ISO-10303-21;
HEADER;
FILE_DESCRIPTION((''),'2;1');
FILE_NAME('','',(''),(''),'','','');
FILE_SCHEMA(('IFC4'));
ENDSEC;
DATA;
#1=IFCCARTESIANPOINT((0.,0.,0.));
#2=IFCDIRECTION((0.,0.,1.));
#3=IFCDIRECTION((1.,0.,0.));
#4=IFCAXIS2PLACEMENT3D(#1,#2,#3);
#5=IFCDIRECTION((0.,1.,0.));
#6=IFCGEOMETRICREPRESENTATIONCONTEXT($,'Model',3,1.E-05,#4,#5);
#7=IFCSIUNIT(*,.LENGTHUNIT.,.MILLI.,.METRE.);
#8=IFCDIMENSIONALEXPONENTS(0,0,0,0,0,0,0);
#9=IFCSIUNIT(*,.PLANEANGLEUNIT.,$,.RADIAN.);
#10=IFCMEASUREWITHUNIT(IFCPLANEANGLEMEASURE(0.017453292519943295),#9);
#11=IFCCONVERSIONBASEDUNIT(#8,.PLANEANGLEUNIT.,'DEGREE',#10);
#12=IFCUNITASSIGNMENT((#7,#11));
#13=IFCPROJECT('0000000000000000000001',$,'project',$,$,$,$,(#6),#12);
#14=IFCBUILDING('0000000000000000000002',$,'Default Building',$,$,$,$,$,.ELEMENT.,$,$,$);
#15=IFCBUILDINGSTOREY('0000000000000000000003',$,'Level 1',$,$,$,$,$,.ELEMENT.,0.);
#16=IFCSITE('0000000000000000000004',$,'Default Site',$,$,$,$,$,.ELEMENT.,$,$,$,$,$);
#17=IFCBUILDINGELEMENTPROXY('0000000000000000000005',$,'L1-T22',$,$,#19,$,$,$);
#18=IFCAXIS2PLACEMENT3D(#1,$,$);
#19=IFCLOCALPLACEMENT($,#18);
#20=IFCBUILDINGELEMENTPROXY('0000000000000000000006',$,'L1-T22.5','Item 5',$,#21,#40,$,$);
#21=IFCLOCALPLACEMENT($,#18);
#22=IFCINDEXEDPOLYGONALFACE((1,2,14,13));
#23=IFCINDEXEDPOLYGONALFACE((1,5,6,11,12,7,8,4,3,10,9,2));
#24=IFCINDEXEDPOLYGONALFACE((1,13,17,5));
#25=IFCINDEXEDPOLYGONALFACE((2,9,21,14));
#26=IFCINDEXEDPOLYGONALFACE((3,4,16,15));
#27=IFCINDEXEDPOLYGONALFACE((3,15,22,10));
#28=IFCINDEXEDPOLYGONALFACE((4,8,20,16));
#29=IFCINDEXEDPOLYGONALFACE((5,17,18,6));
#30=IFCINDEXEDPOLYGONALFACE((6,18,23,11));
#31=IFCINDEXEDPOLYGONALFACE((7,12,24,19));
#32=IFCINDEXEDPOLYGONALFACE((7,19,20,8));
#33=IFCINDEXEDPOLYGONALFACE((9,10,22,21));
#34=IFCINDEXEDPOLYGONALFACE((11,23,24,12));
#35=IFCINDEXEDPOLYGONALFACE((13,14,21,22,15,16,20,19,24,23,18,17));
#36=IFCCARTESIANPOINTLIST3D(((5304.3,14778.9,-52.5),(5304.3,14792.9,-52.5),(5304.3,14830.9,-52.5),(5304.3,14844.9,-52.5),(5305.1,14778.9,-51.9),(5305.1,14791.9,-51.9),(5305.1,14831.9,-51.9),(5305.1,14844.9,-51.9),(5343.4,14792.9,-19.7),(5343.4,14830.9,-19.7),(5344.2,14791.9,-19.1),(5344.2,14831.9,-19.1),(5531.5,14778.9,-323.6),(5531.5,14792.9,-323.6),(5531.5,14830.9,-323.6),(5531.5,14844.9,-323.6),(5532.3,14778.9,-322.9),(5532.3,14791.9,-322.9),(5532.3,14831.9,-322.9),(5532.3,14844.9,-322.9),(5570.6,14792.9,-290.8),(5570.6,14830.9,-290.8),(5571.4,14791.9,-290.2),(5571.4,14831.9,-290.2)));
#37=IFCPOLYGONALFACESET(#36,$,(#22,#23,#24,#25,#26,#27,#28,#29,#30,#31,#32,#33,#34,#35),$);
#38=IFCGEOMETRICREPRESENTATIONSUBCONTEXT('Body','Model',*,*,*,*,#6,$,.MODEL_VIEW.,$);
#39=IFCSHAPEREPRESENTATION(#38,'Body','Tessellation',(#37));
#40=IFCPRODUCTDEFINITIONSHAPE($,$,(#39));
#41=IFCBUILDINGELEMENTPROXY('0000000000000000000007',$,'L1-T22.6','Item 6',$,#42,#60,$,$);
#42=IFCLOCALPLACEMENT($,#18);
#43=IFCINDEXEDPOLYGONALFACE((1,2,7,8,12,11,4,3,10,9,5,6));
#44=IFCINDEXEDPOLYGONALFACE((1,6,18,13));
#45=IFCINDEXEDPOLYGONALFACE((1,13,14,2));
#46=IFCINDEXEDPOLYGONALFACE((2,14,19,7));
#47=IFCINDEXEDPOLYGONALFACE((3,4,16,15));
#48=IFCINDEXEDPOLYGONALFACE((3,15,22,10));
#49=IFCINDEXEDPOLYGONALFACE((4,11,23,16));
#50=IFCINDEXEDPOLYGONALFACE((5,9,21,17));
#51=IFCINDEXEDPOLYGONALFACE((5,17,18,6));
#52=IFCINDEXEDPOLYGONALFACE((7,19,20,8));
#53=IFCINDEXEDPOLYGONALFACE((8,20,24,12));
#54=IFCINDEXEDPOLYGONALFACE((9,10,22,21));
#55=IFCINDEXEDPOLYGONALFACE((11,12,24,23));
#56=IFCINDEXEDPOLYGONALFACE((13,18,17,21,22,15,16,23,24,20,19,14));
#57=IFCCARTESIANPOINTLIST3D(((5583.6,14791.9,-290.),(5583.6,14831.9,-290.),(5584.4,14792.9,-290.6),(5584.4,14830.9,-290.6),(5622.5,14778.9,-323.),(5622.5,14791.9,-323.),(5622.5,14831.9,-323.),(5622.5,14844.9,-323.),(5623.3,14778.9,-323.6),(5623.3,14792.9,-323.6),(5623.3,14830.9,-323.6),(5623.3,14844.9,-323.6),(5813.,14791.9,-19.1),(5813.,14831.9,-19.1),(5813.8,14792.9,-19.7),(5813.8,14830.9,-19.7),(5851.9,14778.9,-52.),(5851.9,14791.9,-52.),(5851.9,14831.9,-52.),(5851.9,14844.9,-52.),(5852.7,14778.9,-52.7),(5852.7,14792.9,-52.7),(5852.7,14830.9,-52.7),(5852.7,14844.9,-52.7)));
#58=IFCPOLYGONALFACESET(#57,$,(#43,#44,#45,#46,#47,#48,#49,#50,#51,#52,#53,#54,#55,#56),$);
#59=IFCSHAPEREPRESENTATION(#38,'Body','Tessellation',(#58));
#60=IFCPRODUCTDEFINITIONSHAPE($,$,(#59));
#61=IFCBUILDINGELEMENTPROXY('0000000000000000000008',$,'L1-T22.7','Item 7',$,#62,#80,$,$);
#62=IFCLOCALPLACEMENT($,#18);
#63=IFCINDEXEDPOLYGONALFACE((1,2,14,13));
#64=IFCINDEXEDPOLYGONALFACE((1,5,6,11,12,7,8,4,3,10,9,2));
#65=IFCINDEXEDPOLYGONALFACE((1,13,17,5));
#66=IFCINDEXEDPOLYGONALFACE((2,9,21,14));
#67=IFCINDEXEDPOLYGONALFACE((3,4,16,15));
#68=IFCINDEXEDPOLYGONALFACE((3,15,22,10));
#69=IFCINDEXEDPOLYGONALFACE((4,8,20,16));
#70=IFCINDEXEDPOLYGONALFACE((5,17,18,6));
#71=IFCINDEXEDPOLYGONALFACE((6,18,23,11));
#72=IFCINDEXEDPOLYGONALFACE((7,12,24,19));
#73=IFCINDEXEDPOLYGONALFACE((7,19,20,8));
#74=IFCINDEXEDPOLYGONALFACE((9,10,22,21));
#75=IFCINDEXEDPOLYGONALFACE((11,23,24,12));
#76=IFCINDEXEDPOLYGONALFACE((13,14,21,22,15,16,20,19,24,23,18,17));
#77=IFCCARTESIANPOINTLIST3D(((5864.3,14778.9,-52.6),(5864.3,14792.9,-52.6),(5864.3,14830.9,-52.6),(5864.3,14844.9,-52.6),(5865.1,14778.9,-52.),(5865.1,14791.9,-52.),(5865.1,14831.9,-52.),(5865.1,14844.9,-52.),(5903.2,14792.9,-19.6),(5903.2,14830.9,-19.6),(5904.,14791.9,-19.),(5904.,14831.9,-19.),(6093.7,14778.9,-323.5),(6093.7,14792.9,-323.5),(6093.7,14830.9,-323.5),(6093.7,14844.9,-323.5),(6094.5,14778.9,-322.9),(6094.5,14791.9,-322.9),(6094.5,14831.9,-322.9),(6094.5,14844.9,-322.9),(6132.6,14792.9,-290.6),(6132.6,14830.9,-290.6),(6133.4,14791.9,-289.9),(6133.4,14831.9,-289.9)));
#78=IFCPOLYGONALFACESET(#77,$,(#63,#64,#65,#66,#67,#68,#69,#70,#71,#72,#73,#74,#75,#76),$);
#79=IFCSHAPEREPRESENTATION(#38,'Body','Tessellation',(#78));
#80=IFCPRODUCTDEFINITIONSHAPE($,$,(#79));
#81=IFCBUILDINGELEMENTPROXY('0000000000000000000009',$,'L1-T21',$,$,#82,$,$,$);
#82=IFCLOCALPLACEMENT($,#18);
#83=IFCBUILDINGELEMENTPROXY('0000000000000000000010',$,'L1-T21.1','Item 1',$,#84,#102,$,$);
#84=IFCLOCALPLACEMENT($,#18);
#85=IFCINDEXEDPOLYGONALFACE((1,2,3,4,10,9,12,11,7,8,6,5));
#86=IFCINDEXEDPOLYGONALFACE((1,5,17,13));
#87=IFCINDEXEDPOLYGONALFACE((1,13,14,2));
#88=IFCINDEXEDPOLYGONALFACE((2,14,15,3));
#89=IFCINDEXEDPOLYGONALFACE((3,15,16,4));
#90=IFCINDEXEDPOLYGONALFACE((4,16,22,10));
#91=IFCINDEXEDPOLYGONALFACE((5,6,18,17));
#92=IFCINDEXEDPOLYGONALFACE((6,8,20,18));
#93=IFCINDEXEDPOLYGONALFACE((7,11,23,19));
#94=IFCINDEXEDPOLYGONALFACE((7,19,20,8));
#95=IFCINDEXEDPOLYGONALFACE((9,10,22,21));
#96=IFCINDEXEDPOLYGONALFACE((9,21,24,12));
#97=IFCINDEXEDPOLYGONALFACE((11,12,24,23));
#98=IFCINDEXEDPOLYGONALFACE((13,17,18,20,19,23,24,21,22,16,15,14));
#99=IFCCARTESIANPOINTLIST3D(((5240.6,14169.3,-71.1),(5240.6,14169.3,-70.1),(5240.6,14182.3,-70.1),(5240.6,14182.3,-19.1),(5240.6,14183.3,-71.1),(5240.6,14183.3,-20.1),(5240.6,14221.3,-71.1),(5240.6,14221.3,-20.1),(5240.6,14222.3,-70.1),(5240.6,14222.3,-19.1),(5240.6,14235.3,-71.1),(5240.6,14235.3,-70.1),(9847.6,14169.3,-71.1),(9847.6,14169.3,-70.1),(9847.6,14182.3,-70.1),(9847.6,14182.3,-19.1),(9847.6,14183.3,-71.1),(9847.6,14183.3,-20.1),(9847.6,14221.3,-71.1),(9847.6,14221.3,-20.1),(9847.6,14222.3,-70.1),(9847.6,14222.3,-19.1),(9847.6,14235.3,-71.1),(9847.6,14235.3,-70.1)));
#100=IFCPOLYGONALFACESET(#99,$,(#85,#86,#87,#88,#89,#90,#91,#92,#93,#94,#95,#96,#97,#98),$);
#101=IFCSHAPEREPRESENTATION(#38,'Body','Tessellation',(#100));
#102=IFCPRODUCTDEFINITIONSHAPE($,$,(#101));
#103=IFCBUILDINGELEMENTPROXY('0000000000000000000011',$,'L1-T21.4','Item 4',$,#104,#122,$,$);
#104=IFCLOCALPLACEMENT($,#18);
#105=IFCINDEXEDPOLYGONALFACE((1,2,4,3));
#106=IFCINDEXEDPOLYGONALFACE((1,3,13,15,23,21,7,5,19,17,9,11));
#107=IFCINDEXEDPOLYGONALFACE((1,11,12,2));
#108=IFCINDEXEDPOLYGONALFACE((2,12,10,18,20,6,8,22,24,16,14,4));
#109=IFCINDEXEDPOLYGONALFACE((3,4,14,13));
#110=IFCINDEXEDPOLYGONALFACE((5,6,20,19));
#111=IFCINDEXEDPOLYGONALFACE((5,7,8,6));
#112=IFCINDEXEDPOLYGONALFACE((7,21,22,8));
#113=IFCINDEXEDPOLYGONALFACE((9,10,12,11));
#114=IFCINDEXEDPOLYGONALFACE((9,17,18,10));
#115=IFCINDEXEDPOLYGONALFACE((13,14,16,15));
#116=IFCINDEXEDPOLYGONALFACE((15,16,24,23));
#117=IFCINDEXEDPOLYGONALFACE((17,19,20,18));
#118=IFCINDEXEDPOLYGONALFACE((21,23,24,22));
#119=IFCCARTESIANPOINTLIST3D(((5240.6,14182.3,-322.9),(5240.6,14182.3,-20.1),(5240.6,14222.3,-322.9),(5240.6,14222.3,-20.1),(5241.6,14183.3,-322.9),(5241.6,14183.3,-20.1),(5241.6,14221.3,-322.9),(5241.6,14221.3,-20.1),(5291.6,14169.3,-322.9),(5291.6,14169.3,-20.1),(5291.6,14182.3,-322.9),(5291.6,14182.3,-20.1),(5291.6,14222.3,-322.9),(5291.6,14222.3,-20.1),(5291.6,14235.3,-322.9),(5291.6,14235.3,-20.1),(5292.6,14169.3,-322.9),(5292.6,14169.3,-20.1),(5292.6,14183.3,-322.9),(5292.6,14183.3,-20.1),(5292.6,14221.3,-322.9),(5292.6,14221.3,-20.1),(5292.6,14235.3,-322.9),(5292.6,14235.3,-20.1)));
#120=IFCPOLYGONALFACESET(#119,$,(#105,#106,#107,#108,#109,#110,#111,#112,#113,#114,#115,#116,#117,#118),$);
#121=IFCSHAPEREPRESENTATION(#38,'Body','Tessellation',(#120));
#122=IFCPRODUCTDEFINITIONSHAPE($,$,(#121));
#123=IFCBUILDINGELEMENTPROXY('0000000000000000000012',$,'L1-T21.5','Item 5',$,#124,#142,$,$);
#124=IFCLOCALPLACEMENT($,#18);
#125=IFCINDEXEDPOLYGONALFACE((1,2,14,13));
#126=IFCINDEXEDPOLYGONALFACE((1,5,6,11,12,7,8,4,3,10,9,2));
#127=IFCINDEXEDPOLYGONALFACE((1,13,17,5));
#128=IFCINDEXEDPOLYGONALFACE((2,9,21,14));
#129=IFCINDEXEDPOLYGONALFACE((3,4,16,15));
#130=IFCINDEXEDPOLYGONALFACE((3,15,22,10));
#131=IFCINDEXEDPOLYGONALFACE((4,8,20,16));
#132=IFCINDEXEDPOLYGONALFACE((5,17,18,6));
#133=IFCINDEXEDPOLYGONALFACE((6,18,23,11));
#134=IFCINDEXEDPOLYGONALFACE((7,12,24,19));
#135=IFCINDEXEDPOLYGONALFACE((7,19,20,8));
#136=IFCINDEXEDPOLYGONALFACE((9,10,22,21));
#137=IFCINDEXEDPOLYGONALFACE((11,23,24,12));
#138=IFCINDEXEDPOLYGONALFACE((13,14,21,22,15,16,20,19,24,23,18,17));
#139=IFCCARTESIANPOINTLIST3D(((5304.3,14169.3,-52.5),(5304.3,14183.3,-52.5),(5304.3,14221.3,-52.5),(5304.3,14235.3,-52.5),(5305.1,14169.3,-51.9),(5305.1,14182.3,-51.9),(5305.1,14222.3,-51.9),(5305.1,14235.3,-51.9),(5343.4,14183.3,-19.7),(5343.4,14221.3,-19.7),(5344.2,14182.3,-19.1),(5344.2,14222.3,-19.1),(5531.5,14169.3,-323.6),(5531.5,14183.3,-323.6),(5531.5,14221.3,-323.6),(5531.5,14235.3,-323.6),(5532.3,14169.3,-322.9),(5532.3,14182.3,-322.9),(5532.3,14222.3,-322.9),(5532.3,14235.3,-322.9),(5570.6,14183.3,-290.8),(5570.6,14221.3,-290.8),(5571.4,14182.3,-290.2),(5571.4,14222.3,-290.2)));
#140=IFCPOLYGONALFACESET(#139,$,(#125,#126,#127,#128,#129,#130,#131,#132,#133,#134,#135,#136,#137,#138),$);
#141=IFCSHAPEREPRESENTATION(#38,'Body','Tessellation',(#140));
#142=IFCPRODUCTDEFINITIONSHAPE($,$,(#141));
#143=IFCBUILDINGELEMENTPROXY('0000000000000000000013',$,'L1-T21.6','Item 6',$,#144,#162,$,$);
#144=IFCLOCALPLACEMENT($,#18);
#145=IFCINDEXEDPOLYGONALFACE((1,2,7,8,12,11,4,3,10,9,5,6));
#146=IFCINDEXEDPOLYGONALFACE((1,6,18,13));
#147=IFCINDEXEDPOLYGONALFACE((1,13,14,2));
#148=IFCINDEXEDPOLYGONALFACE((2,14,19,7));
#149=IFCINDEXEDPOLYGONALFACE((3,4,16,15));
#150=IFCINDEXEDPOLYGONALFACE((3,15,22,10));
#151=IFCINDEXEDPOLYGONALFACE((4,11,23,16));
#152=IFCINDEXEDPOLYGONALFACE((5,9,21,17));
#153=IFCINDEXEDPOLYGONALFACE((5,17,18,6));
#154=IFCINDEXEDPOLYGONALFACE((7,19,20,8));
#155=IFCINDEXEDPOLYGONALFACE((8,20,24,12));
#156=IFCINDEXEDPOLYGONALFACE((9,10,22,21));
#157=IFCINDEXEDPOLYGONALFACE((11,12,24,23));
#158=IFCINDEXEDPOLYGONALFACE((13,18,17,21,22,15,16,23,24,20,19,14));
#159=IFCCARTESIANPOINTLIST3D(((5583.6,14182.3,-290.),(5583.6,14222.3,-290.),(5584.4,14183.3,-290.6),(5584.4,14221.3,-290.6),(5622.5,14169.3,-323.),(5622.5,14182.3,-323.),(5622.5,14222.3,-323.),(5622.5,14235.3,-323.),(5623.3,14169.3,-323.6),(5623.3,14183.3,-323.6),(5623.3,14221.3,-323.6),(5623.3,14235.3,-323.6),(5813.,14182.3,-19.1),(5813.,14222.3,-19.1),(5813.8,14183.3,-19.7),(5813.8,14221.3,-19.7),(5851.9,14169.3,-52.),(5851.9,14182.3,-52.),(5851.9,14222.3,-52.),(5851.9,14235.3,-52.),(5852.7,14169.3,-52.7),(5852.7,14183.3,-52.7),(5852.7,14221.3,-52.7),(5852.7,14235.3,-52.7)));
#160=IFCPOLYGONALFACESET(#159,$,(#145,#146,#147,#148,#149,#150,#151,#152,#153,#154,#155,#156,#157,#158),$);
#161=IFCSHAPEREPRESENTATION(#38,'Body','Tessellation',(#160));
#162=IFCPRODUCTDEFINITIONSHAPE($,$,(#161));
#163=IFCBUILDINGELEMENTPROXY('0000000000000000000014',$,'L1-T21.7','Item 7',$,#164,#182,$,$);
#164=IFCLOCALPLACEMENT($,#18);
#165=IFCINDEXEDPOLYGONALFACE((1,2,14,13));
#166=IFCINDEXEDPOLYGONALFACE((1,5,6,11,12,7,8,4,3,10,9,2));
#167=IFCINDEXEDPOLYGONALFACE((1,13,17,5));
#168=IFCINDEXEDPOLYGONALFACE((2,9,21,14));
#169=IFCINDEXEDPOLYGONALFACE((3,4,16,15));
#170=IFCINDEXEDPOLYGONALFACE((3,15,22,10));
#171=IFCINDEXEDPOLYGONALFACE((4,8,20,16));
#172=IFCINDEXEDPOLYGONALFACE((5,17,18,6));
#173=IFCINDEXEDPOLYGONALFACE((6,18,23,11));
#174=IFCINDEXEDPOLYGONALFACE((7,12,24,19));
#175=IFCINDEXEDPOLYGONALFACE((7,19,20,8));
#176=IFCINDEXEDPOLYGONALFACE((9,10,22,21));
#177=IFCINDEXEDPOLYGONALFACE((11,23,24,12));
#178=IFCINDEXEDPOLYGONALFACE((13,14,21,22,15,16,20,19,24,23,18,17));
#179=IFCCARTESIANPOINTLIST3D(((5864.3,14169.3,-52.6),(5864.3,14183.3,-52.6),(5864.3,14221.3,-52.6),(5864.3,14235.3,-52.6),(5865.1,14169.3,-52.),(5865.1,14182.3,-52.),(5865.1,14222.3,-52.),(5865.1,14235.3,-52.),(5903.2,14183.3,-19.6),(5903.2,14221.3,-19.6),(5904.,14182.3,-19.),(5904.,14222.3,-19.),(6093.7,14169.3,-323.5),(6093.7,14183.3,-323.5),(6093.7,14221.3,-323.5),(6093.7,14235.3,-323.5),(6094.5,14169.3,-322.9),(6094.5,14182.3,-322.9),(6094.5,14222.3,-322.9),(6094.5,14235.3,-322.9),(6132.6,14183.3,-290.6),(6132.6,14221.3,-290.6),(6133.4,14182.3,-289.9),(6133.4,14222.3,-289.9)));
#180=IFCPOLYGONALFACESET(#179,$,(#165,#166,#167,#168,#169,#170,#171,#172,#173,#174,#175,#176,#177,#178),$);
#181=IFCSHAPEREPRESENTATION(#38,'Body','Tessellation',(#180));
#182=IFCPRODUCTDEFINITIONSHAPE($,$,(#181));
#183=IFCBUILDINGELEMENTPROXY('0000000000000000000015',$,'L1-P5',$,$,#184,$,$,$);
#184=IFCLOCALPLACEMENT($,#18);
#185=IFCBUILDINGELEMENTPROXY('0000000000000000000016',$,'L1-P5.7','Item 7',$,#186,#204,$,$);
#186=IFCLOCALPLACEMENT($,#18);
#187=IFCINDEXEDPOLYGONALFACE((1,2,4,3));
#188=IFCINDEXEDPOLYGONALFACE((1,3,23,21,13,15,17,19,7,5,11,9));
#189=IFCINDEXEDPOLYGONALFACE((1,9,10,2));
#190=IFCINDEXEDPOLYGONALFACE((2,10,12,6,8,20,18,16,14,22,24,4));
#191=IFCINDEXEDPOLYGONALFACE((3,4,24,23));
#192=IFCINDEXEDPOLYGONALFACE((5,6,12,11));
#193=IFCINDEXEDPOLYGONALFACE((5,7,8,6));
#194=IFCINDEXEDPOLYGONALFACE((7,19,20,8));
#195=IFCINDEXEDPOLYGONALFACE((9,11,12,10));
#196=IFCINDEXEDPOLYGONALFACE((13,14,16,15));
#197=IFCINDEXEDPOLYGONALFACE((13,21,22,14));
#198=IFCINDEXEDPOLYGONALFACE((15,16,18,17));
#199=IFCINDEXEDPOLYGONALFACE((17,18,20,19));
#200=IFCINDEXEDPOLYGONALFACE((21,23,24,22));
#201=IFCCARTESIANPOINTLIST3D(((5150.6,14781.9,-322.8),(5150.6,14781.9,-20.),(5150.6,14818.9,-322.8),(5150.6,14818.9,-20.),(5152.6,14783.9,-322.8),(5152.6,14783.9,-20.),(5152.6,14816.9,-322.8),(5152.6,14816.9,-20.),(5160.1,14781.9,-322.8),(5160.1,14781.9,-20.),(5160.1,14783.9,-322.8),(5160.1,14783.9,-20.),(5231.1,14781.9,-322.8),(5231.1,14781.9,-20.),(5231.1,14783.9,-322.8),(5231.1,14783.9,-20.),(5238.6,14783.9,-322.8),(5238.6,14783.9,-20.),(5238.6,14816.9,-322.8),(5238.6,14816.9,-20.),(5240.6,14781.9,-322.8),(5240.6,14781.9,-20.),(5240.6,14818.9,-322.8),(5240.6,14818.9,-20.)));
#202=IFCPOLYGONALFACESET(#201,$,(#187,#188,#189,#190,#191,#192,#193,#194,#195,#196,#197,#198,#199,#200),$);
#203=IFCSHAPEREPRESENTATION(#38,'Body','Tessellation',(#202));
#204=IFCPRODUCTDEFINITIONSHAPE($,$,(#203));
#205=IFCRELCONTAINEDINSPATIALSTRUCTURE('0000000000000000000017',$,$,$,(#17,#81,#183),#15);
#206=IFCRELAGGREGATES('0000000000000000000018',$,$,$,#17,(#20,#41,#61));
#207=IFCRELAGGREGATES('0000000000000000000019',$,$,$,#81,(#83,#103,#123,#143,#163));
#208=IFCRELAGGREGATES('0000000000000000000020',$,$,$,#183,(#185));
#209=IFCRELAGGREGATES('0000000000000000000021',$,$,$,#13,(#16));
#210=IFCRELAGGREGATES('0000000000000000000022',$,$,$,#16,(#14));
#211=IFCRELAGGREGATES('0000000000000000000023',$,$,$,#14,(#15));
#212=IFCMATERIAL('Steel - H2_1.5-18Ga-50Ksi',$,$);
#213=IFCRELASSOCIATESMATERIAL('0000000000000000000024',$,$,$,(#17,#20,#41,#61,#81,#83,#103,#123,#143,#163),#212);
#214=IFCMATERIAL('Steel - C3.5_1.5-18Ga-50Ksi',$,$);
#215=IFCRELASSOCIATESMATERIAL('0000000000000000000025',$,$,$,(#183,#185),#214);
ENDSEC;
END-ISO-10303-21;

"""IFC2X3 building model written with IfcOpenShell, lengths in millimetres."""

from ifc_helpers import new_model, entity, si_unit, converted_unit, direction, frame, origin, origin_with_axes, origin_2d_with_axis, place, context, subcontext, project, spatial, polyline, c_section, outline, extrude, material, element, aggregate, save


model = new_model("IFC2X3")

# Units and contexts
model_context = context("Model", 3, precision=1e-05, world=origin_with_axes(), true_north=direction((0.0, 1.0, 0.0)))
body_context = subcontext(model_context, "Body", "Model", "MODEL_VIEW")
ifc_project = project(units=[si_unit("LENGTHUNIT", "METRE", prefix="MILLI"), converted_unit("PLANEANGLEUNIT", "DEGREE", entity("IfcPlaneAngleMeasure", 0.017453292519943295), si_unit("PLANEANGLEUNIT", "RADIAN"), dimensions=[0, 0, 0, 0, 0, 0, 0])], contexts=[model_context])

# Site, building, storey
site = spatial("IfcSite", under=ifc_project, Name="Default Site", CompositionType="ELEMENT")
building = spatial("IfcBuilding", under=site, Name="Default Building", CompositionType="ELEMENT")
storey = spatial("IfcBuildingStorey", under=building, Name="Level 1", CompositionType="ELEMENT", Elevation=0.0)

# Shared definitions
ifc_material_1 = material(Name="Steel - C3.5_1.5-18Ga-50Ksi")

# Building element proxies
ifc_material_2 = material(Name="Steel - H2_1.5-18Ga-50Ksi")
proxy_1 = element("IfcBuildingElementProxy", 1, inside=storey, material=ifc_material_2, Name="L1-T22")
proxy_2_placement = place(None, frame((5304.3, 14778.9, -52.5), z_axis=(0.642, 0.0, -0.766), x_axis=(0.0, 40.0, 0.0)))
proxy_2 = element("IfcBuildingElementProxy", 2, at=proxy_2_placement, material=ifc_material_2, Name="L1-T22.5", Description="Item 5", context=body_context, shape_type="SweptSolid", body=[
    extrude(outline(polyline([(0.0, 0.0), (14.0, 0.0), (14.0, 51.0), (52.0, 51.0), (52.0, 0.0), (66.0, 0.0), (66.0, 1.0), (53.0, 1.0), (53.0, 52.0), (13.0, 52.0), (13.0, 1.0), (0.0, 1.0), (0.0, 0.0)])), origin(), (0.0, 0.0, 1.0), 353.7),
])
proxy_3_placement = place(None, frame((5623.3, 14778.9, -323.6), z_axis=(0.646, 0.0, 0.763), x_axis=(0.0, 40.0, 0.0)))
proxy_3 = element("IfcBuildingElementProxy", 3, at=proxy_3_placement, material=ifc_material_2, Name="L1-T22.6", Description="Item 6", context=body_context, shape_type="SweptSolid", body=[
    extrude(outline(polyline([(0.0, 0.0), (14.0, 0.0), (14.0, 51.0), (52.0, 51.0), (52.0, 0.0), (66.0, 0.0), (66.0, 1.0), (53.0, 1.0), (53.0, 52.0), (13.0, 52.0), (13.0, 1.0), (0.0, 1.0), (0.0, 0.0)])), origin(), (0.0, 0.0, 1.0), 355.0),
])
proxy_4_placement = place(None, frame((5864.3, 14778.9, -52.6), z_axis=(0.646, 0.0, -0.763), x_axis=(0.0, 40.0, 0.0)))
proxy_4 = element("IfcBuildingElementProxy", 4, at=proxy_4_placement, material=ifc_material_2, Name="L1-T22.7", Description="Item 7", context=body_context, shape_type="SweptSolid", body=[
    extrude(outline(polyline([(0.0, 0.0), (14.0, 0.0), (14.0, 51.0), (52.0, 51.0), (52.0, 0.0), (66.0, 0.0), (66.0, 1.0), (53.0, 1.0), (53.0, 52.0), (13.0, 52.0), (13.0, 1.0), (0.0, 1.0), (0.0, 0.0)])), origin(), (0.0, 0.0, 1.0), 355.0),
])
aggregate(proxy_1, [proxy_2, proxy_3, proxy_4])
proxy_5 = element("IfcBuildingElementProxy", 5, inside=storey, material=ifc_material_2, Name="L1-T21")
proxy_6_placement = place(None, frame((5240.6, 14169.3, -71.1), z_axis=(1.0, 0.0, 0.0), x_axis=(0.0, 40.0, 0.0)))
proxy_6 = element("IfcBuildingElementProxy", 6, at=proxy_6_placement, material=ifc_material_2, Name="L1-T21.1", Description="Item 1", context=body_context, shape_type="SweptSolid", body=[
    extrude(outline(polyline([(0.0, 0.0), (14.0, 0.0), (14.0, 51.0), (52.0, 51.0), (52.0, 0.0), (66.0, 0.0), (66.0, 1.0), (53.0, 1.0), (53.0, 52.0), (13.0, 52.0), (13.0, 1.0), (0.0, 1.0), (0.0, 0.0)])), origin(), (0.0, 0.0, 1.0), 4607.0),
])
proxy_7_placement = place(None, frame((5292.6, 14169.3, -322.9), z_axis=(0.0, 0.0, 1.0), x_axis=(0.0, 40.0, 0.0)))
proxy_7 = element("IfcBuildingElementProxy", 7, at=proxy_7_placement, material=ifc_material_2, Name="L1-T21.4", Description="Item 4", context=body_context, shape_type="SweptSolid", body=[
    extrude(outline(polyline([(0.0, 0.0), (14.0, 0.0), (14.0, 51.0), (52.0, 51.0), (52.0, 0.0), (66.0, 0.0), (66.0, 1.0), (53.0, 1.0), (53.0, 52.0), (13.0, 52.0), (13.0, 1.0), (0.0, 1.0), (0.0, 0.0)])), origin(), (0.0, 0.0, 1.0), 302.8),
])
proxy_8_placement = place(None, frame((5304.3, 14169.3, -52.5), z_axis=(0.642, 0.0, -0.766), x_axis=(0.0, 40.0, 0.0)))
proxy_8 = element("IfcBuildingElementProxy", 8, at=proxy_8_placement, material=ifc_material_2, Name="L1-T21.5", Description="Item 5", context=body_context, shape_type="SweptSolid", body=[
    extrude(outline(polyline([(0.0, 0.0), (14.0, 0.0), (14.0, 51.0), (52.0, 51.0), (52.0, 0.0), (66.0, 0.0), (66.0, 1.0), (53.0, 1.0), (53.0, 52.0), (13.0, 52.0), (13.0, 1.0), (0.0, 1.0), (0.0, 0.0)])), origin(), (0.0, 0.0, 1.0), 353.7),
])
proxy_9_placement = place(None, frame((5623.3, 14169.3, -323.6), z_axis=(0.646, 0.0, 0.763), x_axis=(0.0, 40.0, 0.0)))
proxy_9 = element("IfcBuildingElementProxy", 9, at=proxy_9_placement, material=ifc_material_2, Name="L1-T21.6", Description="Item 6", context=body_context, shape_type="SweptSolid", body=[
    extrude(outline(polyline([(0.0, 0.0), (14.0, 0.0), (14.0, 51.0), (52.0, 51.0), (52.0, 0.0), (66.0, 0.0), (66.0, 1.0), (53.0, 1.0), (53.0, 52.0), (13.0, 52.0), (13.0, 1.0), (0.0, 1.0), (0.0, 0.0)])), origin(), (0.0, 0.0, 1.0), 355.0),
])
proxy_10_placement = place(None, frame((5864.3, 14169.3, -52.6), z_axis=(0.646, 0.0, -0.763), x_axis=(0.0, 40.0, 0.0)))
proxy_10 = element("IfcBuildingElementProxy", 10, at=proxy_10_placement, material=ifc_material_2, Name="L1-T21.7", Description="Item 7", context=body_context, shape_type="SweptSolid", body=[
    extrude(outline(polyline([(0.0, 0.0), (14.0, 0.0), (14.0, 51.0), (52.0, 51.0), (52.0, 0.0), (66.0, 0.0), (66.0, 1.0), (53.0, 1.0), (53.0, 52.0), (13.0, 52.0), (13.0, 1.0), (0.0, 1.0), (0.0, 0.0)])), origin(), (0.0, 0.0, 1.0), 355.0),
])
aggregate(proxy_5, [proxy_6, proxy_7, proxy_8, proxy_9, proxy_10])
proxy_11 = element("IfcBuildingElementProxy", 11, inside=storey, material=ifc_material_1, Name="L1-P5")
proxy_12_placement = place(None, frame((5195.6, 14800.4, -322.8), z_axis=(0.0, 0.0, 1.0), x_axis=(0.0, -37.0, 0.0)))
proxy_12 = element("IfcBuildingElementProxy", 12, at=proxy_12_placement, material=ifc_material_1, Name="L1-P5.7", Description="Item 7", context=body_context, shape_type="SweptSolid", body=[
    extrude(c_section(Depth=90.0, Width=37.0, WallThickness=2.0, Girth=9.5, at=origin_2d_with_axis()), origin(), (0.0, 0.0, 1.0), 302.8),
])
aggregate(proxy_11, [proxy_12])

save(model, "model.ifc")
